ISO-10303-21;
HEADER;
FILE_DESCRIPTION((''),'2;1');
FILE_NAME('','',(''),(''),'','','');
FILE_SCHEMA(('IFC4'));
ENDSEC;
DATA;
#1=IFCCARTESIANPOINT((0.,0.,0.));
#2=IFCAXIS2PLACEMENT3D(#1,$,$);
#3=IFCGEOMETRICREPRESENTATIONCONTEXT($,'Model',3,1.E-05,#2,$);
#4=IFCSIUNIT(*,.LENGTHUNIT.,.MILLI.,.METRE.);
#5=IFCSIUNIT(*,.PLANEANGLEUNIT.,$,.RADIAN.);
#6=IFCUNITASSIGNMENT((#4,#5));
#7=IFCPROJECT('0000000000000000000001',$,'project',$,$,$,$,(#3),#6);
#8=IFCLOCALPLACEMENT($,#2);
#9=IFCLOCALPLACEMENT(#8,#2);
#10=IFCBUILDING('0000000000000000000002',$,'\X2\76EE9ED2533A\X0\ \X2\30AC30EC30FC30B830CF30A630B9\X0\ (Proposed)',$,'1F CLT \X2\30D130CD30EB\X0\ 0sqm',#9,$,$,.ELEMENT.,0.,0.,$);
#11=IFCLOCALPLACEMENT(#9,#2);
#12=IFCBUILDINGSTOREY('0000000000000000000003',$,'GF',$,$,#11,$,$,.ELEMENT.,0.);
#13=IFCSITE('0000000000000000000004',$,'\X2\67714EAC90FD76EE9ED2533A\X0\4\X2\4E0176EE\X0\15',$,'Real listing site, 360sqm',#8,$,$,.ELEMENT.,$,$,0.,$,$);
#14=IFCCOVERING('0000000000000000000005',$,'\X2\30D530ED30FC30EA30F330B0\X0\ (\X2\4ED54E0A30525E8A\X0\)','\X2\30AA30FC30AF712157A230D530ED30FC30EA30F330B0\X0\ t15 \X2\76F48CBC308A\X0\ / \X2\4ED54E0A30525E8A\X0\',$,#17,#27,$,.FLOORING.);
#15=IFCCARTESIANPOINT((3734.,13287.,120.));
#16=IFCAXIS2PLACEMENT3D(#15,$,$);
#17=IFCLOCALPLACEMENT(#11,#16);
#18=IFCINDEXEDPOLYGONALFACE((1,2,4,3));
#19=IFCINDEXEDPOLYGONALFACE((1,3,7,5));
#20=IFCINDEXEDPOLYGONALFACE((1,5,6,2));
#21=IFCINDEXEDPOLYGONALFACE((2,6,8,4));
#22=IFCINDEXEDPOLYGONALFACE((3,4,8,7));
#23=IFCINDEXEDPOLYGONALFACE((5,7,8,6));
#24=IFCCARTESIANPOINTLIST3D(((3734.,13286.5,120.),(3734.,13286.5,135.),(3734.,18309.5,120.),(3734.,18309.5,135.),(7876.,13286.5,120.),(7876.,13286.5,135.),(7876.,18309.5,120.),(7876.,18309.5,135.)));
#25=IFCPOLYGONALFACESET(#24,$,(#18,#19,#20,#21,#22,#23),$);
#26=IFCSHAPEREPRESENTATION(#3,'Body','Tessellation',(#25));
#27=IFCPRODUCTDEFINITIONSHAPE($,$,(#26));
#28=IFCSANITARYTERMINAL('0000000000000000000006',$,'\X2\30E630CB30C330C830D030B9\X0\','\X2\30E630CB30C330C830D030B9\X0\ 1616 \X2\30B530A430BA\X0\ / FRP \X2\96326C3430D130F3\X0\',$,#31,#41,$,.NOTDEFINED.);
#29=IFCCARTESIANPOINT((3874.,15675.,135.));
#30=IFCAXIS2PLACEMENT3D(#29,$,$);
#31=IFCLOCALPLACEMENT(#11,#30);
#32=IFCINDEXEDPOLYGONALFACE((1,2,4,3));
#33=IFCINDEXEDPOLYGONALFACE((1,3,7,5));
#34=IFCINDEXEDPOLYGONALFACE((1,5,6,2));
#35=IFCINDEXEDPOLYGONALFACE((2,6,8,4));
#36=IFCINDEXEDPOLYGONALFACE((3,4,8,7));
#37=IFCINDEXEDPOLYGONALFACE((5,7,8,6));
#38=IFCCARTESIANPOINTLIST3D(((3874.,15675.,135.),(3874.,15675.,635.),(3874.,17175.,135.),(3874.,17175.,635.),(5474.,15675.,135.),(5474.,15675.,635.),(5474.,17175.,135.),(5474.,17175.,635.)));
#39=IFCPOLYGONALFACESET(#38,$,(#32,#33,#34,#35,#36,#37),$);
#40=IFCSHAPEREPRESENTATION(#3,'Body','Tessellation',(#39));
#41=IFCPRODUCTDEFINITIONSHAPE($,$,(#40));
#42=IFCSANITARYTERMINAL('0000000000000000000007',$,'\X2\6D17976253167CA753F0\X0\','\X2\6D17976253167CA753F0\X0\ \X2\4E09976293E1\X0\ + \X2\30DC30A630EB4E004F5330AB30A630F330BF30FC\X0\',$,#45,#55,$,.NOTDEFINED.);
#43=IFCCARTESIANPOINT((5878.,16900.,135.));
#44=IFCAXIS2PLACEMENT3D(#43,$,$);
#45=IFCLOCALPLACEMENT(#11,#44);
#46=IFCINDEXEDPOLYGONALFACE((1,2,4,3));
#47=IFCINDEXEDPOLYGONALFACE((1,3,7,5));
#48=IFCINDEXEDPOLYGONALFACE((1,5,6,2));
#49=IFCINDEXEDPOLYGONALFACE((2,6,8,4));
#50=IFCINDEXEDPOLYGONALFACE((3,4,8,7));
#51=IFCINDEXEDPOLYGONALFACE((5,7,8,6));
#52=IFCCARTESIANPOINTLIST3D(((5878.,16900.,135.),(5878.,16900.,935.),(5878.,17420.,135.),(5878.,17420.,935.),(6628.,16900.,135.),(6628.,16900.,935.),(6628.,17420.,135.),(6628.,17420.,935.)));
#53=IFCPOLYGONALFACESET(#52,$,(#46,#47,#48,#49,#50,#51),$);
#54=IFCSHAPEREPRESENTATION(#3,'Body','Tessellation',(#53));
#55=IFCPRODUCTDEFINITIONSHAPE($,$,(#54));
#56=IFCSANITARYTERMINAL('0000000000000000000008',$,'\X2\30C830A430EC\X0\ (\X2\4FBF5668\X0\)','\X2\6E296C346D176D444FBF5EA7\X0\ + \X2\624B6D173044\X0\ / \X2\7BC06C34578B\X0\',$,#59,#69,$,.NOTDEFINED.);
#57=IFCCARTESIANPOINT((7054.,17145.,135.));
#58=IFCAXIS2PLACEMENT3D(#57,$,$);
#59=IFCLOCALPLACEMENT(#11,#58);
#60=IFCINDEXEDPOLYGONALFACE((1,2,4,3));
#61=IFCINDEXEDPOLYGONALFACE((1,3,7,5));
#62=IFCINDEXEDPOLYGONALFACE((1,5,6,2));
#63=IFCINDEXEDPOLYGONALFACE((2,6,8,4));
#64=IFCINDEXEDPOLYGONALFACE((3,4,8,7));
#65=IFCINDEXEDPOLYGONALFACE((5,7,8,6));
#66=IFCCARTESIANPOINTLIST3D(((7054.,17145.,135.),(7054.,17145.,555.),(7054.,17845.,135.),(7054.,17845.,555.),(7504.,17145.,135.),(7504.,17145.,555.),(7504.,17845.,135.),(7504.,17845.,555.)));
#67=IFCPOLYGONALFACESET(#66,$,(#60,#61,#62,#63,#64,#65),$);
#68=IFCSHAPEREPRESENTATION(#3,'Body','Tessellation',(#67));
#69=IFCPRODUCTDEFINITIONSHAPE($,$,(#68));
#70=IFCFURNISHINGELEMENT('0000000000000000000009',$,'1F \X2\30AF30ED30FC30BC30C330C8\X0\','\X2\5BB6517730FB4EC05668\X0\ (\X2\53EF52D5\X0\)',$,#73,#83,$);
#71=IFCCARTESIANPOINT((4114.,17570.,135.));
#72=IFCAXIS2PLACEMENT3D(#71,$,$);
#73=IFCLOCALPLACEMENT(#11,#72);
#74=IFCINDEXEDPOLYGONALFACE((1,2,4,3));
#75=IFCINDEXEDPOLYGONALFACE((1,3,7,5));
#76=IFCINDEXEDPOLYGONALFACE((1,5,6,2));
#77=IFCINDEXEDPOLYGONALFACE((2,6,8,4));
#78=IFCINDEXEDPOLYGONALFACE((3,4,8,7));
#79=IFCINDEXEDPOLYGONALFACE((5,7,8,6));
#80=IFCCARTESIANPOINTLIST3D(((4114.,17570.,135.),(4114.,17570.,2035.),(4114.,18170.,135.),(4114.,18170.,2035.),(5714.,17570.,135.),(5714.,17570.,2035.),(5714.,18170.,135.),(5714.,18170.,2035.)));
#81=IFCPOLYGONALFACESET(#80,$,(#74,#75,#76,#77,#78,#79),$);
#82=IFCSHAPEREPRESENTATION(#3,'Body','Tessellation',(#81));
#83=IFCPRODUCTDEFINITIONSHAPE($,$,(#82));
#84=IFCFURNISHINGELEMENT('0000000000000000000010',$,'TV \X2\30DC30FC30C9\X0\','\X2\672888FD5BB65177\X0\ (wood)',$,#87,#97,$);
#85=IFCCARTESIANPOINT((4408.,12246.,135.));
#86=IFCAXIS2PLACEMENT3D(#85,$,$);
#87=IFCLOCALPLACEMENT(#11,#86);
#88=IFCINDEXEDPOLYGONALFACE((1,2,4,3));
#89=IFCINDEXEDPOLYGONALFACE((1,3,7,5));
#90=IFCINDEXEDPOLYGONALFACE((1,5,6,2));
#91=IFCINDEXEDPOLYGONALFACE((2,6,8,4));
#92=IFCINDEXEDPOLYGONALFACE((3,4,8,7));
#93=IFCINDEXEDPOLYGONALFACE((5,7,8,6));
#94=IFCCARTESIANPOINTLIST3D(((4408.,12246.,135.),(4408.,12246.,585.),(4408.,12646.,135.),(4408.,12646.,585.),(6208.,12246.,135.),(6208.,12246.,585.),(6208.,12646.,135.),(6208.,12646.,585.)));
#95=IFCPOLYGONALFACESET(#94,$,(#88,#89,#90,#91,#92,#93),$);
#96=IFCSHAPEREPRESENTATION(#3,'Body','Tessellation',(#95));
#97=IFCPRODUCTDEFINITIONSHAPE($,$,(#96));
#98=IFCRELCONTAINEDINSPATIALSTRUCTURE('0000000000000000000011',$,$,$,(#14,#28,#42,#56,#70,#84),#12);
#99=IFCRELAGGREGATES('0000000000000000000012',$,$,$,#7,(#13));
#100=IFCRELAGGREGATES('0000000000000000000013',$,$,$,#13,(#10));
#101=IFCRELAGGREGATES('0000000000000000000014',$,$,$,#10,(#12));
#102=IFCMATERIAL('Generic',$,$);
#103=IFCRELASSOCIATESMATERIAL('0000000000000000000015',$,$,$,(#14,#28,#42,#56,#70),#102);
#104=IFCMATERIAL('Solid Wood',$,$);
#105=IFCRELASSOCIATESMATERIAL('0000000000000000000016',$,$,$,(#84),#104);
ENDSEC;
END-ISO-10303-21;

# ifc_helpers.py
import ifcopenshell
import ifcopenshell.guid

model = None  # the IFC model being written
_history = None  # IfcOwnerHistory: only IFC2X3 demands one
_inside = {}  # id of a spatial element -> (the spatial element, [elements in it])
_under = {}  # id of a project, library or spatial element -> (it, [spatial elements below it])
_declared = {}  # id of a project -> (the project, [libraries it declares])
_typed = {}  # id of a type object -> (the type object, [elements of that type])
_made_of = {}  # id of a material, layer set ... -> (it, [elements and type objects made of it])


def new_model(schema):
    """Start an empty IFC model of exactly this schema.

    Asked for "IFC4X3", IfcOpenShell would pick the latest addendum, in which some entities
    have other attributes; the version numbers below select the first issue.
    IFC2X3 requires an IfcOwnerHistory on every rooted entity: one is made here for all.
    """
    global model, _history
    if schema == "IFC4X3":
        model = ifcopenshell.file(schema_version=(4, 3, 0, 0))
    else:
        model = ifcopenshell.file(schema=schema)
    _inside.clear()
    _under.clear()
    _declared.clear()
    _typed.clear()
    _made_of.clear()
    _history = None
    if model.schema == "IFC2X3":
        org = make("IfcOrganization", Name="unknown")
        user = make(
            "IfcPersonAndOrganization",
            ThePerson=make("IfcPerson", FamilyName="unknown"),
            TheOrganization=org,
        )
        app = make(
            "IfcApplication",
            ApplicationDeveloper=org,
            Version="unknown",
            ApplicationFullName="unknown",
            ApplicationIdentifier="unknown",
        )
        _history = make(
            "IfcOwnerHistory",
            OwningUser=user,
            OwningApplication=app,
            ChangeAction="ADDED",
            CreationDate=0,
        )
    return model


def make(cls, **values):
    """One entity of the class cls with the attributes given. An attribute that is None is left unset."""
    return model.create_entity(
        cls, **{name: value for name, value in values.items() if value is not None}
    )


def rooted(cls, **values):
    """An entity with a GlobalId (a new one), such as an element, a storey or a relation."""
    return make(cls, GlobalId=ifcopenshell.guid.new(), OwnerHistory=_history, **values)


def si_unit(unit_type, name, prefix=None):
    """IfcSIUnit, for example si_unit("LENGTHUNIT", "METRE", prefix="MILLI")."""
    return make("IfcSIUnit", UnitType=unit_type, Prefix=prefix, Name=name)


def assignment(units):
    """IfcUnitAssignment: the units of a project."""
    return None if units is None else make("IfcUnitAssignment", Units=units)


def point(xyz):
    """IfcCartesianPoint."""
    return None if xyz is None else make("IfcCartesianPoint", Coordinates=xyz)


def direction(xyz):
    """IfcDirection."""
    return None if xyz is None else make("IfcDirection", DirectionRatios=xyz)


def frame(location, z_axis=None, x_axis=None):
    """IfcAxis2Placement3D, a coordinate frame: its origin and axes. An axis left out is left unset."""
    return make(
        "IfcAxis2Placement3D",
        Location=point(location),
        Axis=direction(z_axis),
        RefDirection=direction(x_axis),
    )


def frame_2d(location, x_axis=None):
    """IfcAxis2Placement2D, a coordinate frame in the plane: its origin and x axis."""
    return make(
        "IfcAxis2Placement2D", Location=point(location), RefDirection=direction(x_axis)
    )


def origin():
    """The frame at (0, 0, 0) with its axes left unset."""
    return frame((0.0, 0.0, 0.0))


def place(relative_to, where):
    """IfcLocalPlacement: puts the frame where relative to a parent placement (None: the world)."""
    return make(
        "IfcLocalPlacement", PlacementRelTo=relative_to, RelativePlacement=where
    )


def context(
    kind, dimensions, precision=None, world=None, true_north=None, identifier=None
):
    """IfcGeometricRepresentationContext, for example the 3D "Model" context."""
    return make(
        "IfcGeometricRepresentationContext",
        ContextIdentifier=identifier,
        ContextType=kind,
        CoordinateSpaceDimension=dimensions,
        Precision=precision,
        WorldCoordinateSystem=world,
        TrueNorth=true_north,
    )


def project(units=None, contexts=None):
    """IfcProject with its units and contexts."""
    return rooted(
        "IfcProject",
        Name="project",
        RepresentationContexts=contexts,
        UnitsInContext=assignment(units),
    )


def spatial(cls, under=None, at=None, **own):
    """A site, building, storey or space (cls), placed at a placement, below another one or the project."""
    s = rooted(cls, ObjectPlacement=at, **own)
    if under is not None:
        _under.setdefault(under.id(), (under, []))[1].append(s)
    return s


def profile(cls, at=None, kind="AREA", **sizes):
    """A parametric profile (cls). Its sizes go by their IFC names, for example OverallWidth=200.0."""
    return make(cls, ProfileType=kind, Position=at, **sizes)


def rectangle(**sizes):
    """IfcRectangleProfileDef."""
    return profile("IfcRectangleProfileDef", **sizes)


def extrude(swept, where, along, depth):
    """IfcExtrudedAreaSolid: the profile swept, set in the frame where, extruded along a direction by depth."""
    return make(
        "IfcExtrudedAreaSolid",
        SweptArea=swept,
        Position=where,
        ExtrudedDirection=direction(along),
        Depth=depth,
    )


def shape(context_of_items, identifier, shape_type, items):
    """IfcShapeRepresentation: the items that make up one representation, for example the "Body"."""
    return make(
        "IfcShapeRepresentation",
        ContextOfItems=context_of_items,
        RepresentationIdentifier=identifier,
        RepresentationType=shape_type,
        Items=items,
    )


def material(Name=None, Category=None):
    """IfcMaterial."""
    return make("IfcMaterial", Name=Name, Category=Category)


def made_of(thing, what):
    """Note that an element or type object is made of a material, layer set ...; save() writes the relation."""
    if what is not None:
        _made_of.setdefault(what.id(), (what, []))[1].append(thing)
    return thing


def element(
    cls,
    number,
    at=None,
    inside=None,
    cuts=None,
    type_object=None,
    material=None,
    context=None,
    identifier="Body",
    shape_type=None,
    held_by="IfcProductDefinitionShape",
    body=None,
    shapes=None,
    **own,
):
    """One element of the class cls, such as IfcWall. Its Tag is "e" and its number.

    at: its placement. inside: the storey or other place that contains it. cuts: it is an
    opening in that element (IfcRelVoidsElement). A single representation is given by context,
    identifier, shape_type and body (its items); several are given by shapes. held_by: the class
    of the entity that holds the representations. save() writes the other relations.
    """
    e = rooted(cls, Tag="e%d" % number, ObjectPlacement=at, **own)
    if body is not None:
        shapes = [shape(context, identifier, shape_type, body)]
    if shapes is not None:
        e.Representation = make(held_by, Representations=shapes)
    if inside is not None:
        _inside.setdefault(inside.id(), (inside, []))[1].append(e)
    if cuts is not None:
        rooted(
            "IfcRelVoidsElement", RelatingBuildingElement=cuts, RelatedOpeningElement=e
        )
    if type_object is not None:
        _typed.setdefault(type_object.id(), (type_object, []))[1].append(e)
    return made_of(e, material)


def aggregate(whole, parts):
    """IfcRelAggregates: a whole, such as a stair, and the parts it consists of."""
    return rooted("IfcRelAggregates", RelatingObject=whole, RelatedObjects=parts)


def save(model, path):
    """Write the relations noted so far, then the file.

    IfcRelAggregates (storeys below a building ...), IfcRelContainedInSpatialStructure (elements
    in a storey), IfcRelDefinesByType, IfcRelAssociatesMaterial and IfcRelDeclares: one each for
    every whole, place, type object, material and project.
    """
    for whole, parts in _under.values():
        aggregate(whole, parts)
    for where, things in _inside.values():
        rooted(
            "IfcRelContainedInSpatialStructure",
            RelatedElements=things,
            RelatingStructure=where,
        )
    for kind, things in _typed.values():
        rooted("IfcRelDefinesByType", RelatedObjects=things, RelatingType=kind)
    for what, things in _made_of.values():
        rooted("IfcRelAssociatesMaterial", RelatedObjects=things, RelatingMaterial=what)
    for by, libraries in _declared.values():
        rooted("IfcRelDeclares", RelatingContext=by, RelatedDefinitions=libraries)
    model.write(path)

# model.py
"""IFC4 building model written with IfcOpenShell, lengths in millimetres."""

from ifc_helpers import new_model, si_unit, frame, frame_2d, origin, place, context, project, spatial, rectangle, extrude, material, element, save


model = new_model("IFC4")

# Units and contexts
model_context = context("Model", 3, precision=1e-05, world=origin())
ifc_project = project(units=[si_unit("LENGTHUNIT", "METRE", prefix="MILLI"), si_unit("PLANEANGLEUNIT", "RADIAN")], contexts=[model_context])

# Site, building, storey
site_placement = place(None, origin())
site = spatial("IfcSite", under=ifc_project, at=site_placement, Name="東京都目黒区4丁目15", ObjectType="Real listing site, 360sqm", CompositionType="ELEMENT", RefElevation=0.0)
building_placement = place(site_placement, origin())
building = spatial("IfcBuilding", under=site, at=building_placement, Name="目黒区 ガレージハウス (Proposed)", ObjectType="1F CLT パネル 0sqm", CompositionType="ELEMENT", ElevationOfRefHeight=0.0, ElevationOfTerrain=0.0)
storey_placement = place(building_placement, origin())
storey = spatial("IfcBuildingStorey", under=building, at=storey_placement, Name="GF", CompositionType="ELEMENT", Elevation=0.0)

# Shared definitions
ifc_material_1 = material(Name="Solid Wood")

# Covering
ifc_material_2 = material(Name="Generic")
covering_placement = place(storey_placement, frame((3734.0, 13287.0, 120.0)))
element("IfcCovering", 1, at=covering_placement, inside=storey, material=ifc_material_2, Name="フローリング (仕上げ床)", Description="オーク無垢フローリング t15 直貼り / 仕上げ床", PredefinedType="FLOORING", context=model_context, shape_type="SweptSolid", body=[
    extrude(rectangle(XDim=4142.0, YDim=5023.0, at=frame_2d((2071.0, 2511.0))), frame((3734.0, 13287.0, 120.0)), (0.0, 0.0, 1.0), 15.0),
])

# Sanitary terminals
sanitary_terminal_1_placement = place(storey_placement, frame((3874.0, 15675.0, 135.0)))
element("IfcSanitaryTerminal", 2, at=sanitary_terminal_1_placement, inside=storey, material=ifc_material_2, Name="ユニットバス", Description="ユニットバス 1616 サイズ / FRP 防水パン", PredefinedType="NOTDEFINED", context=model_context, shape_type="SweptSolid", body=[
    extrude(rectangle(XDim=1600.0, YDim=1500.0, at=frame_2d((800.0, 750.0))), frame((3874.0, 15675.0, 135.0)), (0.0, 0.0, 1.0), 500.0),
])
sanitary_terminal_2_placement = place(storey_placement, frame((5878.0, 16900.0, 135.0)))
element("IfcSanitaryTerminal", 3, at=sanitary_terminal_2_placement, inside=storey, material=ifc_material_2, Name="洗面化粧台", Description="洗面化粧台 三面鏡 + ボウル一体カウンター", PredefinedType="NOTDEFINED", context=model_context, shape_type="SweptSolid", body=[
    extrude(rectangle(XDim=750.0, YDim=520.0, at=frame_2d((375.0, 260.0))), frame((5878.0, 16900.0, 135.0)), (0.0, 0.0, 1.0), 800.0),
])
sanitary_terminal_3_placement = place(storey_placement, frame((7054.0, 17145.0, 135.0)))
element("IfcSanitaryTerminal", 4, at=sanitary_terminal_3_placement, inside=storey, material=ifc_material_2, Name="トイレ (便器)", Description="温水洗浄便座 + 手洗い / 節水型", PredefinedType="NOTDEFINED", context=model_context, shape_type="SweptSolid", body=[
    extrude(rectangle(XDim=450.0, YDim=700.0, at=frame_2d((225.0, 350.0))), frame((7054.0, 17145.0, 135.0)), (0.0, 0.0, 1.0), 420.0),
])

# Furnishing elements
furnishing_1_placement = place(storey_placement, frame((4114.0, 17570.0, 135.0)))
element("IfcFurnishingElement", 5, at=furnishing_1_placement, inside=storey, material=ifc_material_2, Name="1F クローゼット", Description="家具・什器 (可動)", context=model_context, shape_type="SweptSolid", body=[
    extrude(rectangle(XDim=1600.0, YDim=600.0, at=frame_2d((800.0, 300.0))), frame((4114.0, 17570.0, 135.0)), (0.0, 0.0, 1.0), 1900.0),
])
furnishing_2_placement = place(storey_placement, frame((4408.0, 12246.0, 135.0)))
element("IfcFurnishingElement", 6, at=furnishing_2_placement, inside=storey, material=ifc_material_1, Name="TV ボード", Description="木製家具 (wood)", context=model_context, shape_type="SweptSolid", body=[
    extrude(rectangle(XDim=1800.0, YDim=400.0, at=frame_2d((900.0, 200.0))), frame((4408.0, 12246.0, 135.0)), (0.0, 0.0, 1.0), 450.0),
])

save(model, "model.ifc")
